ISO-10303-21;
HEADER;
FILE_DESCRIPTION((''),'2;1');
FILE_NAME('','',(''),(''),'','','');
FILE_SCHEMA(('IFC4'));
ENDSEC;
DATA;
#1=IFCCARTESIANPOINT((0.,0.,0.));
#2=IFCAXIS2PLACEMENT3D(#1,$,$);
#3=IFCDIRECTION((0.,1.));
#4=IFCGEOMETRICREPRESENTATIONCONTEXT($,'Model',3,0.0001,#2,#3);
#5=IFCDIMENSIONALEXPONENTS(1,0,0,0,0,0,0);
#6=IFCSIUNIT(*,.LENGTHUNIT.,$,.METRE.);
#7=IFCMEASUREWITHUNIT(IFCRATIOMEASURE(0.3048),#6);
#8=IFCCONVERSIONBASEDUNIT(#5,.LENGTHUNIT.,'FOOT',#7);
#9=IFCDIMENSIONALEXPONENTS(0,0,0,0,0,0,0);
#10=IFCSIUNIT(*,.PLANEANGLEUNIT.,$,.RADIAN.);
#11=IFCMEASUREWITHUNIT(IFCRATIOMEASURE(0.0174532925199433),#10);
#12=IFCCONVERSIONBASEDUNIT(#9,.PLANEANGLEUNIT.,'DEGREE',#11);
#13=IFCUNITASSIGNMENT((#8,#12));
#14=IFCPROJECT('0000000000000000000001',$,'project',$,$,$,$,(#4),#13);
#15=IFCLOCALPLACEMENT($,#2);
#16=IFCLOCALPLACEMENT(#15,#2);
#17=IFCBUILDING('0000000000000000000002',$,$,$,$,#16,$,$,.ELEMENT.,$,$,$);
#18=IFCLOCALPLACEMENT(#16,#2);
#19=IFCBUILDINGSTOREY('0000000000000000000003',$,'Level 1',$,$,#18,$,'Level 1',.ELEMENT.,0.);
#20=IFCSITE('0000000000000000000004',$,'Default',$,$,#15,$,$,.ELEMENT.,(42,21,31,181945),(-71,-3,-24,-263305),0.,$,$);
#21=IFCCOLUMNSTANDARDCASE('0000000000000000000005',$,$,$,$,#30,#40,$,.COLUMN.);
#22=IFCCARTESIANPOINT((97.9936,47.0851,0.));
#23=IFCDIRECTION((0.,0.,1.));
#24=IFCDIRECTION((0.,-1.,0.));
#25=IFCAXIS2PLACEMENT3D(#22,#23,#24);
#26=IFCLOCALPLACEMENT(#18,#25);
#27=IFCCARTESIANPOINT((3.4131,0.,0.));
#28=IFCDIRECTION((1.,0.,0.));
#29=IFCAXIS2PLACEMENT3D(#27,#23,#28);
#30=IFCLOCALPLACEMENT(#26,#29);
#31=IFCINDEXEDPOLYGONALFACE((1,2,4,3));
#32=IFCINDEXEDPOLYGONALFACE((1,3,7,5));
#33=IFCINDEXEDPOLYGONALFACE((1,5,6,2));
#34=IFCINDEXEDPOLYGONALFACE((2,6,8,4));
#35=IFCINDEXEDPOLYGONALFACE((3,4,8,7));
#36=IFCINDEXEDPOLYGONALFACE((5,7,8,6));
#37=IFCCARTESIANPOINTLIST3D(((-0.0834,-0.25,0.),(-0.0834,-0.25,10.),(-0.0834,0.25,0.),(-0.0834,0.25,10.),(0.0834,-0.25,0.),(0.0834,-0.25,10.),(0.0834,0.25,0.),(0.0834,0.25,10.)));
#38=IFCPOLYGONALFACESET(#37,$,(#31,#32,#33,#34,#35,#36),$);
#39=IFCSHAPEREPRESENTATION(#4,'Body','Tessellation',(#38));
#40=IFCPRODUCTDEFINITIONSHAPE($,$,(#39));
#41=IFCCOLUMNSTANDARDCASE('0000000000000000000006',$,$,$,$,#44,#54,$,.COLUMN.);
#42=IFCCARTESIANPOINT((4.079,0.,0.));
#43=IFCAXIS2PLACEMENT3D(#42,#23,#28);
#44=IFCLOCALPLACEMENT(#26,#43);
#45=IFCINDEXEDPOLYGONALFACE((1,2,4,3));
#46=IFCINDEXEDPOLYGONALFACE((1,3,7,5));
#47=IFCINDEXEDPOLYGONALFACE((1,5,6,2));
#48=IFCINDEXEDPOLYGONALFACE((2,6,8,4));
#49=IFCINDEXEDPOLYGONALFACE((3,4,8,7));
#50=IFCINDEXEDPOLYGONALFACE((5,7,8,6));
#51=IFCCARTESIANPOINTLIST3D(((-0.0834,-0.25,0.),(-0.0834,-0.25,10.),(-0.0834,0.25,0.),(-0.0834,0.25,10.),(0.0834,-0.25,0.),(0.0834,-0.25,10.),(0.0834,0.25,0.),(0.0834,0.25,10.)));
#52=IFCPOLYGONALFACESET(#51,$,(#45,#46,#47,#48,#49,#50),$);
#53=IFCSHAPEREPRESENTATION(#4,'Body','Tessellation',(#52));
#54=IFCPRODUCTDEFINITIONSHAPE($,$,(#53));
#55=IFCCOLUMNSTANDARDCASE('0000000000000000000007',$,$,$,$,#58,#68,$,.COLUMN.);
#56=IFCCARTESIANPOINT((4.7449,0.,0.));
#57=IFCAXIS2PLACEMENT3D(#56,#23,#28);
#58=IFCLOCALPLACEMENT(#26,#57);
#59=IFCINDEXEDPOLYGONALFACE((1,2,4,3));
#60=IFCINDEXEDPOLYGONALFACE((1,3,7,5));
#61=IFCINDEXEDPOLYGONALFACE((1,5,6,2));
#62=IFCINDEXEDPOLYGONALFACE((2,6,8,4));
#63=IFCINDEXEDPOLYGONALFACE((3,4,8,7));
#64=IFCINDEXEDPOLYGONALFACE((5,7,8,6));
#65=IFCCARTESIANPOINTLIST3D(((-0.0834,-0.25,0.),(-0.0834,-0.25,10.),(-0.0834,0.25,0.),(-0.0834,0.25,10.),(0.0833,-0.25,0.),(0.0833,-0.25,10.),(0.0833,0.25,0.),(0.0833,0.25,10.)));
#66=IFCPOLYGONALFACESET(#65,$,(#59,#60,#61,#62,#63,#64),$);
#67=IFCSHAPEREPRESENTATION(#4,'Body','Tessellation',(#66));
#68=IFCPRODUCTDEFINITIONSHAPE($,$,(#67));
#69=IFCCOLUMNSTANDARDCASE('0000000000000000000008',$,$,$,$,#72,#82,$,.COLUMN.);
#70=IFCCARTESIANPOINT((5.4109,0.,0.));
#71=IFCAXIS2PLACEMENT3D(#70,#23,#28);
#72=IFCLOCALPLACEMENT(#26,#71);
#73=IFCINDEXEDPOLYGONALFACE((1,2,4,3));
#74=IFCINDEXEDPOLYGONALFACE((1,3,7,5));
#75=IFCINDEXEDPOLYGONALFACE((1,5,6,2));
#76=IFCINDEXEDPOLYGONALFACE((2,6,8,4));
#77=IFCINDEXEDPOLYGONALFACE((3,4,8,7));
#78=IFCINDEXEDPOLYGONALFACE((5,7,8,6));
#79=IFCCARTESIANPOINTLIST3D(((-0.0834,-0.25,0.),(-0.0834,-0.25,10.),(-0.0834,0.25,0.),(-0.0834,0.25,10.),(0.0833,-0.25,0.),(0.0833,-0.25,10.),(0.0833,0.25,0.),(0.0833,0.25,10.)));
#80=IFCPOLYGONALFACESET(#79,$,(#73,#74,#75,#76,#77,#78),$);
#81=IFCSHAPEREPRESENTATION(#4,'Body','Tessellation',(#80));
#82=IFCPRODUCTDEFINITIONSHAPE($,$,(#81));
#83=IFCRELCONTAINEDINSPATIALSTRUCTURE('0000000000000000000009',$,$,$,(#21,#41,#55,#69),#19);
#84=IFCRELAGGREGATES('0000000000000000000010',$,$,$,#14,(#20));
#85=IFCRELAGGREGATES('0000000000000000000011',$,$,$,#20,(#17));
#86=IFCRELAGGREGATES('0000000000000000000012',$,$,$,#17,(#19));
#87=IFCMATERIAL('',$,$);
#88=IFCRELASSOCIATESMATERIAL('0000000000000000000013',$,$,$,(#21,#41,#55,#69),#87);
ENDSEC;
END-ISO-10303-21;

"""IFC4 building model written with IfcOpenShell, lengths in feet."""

from ifc_helpers import new_model, entity, si_unit, converted_unit, direction, frame, origin, place, context, project, spatial, rectangle, extrude, material, element, save


model = new_model("IFC4")

# Units and contexts
model_context = context("Model", 3, precision=0.0001, world=origin(), true_north=direction((0.0, 1.0)))
ifc_project = project(units=[converted_unit("LENGTHUNIT", "FOOT", entity("IfcRatioMeasure", 0.3048), si_unit("LENGTHUNIT", "METRE"), dimensions=[1, 0, 0, 0, 0, 0, 0]), converted_unit("PLANEANGLEUNIT", "DEGREE", entity("IfcRatioMeasure", 0.0174532925199433), si_unit("PLANEANGLEUNIT", "RADIAN"), dimensions=[0, 0, 0, 0, 0, 0, 0])], contexts=[model_context])

# Site, building, storey
site_placement = place(None, origin())
site = spatial("IfcSite", under=ifc_project, at=site_placement, Name="Default", CompositionType="ELEMENT", RefLatitude=(42, 21, 31, 181945), RefLongitude=(-71, -3, -24, -263305), RefElevation=0.0)
building_placement = place(site_placement, origin())
building = spatial("IfcBuilding", under=site, at=building_placement, CompositionType="ELEMENT")
storey_placement = place(building_placement, origin())
storey = spatial("IfcBuildingStorey", under=building, at=storey_placement, Name="Level 1", LongName="Level 1", CompositionType="ELEMENT", Elevation=0.0)

# Columns
ifc_material_1 = material(Name="")
wall_placement = place(storey_placement, frame((97.9936, 47.0851, 0.0), z_axis=(0.0, 0.0, 1.0), x_axis=(0.0, -1.0, 0.0)))
for number, where, z_axis, x_axis in (
    (1, (3.4131, 0.0, 0.0), (0.0, 0.0, 1.0), (1.0, 0.0, 0.0)),
    (2, (4.079, 0.0, 0.0), (0.0, 0.0, 1.0), (1.0, 0.0, 0.0)),
    (3, (4.7449, 0.0, 0.0), (0.0, 0.0, 1.0), (1.0, 0.0, 0.0)),
    (4, (5.4109, 0.0, 0.0), (0.0, 0.0, 1.0), (1.0, 0.0, 0.0)),
):
    element("IfcColumnStandardCase", number, at=place(wall_placement, frame(where, z_axis=z_axis, x_axis=x_axis)), inside=storey, material=ifc_material_1, PredefinedType="COLUMN", context=model_context, shape_type="SweptSolid", body=[
        extrude(rectangle(XDim=0.1667, YDim=0.5), origin(), (0.0, 0.0, 1.0), 10.0),
    ])

save(model, "model.ifc")
